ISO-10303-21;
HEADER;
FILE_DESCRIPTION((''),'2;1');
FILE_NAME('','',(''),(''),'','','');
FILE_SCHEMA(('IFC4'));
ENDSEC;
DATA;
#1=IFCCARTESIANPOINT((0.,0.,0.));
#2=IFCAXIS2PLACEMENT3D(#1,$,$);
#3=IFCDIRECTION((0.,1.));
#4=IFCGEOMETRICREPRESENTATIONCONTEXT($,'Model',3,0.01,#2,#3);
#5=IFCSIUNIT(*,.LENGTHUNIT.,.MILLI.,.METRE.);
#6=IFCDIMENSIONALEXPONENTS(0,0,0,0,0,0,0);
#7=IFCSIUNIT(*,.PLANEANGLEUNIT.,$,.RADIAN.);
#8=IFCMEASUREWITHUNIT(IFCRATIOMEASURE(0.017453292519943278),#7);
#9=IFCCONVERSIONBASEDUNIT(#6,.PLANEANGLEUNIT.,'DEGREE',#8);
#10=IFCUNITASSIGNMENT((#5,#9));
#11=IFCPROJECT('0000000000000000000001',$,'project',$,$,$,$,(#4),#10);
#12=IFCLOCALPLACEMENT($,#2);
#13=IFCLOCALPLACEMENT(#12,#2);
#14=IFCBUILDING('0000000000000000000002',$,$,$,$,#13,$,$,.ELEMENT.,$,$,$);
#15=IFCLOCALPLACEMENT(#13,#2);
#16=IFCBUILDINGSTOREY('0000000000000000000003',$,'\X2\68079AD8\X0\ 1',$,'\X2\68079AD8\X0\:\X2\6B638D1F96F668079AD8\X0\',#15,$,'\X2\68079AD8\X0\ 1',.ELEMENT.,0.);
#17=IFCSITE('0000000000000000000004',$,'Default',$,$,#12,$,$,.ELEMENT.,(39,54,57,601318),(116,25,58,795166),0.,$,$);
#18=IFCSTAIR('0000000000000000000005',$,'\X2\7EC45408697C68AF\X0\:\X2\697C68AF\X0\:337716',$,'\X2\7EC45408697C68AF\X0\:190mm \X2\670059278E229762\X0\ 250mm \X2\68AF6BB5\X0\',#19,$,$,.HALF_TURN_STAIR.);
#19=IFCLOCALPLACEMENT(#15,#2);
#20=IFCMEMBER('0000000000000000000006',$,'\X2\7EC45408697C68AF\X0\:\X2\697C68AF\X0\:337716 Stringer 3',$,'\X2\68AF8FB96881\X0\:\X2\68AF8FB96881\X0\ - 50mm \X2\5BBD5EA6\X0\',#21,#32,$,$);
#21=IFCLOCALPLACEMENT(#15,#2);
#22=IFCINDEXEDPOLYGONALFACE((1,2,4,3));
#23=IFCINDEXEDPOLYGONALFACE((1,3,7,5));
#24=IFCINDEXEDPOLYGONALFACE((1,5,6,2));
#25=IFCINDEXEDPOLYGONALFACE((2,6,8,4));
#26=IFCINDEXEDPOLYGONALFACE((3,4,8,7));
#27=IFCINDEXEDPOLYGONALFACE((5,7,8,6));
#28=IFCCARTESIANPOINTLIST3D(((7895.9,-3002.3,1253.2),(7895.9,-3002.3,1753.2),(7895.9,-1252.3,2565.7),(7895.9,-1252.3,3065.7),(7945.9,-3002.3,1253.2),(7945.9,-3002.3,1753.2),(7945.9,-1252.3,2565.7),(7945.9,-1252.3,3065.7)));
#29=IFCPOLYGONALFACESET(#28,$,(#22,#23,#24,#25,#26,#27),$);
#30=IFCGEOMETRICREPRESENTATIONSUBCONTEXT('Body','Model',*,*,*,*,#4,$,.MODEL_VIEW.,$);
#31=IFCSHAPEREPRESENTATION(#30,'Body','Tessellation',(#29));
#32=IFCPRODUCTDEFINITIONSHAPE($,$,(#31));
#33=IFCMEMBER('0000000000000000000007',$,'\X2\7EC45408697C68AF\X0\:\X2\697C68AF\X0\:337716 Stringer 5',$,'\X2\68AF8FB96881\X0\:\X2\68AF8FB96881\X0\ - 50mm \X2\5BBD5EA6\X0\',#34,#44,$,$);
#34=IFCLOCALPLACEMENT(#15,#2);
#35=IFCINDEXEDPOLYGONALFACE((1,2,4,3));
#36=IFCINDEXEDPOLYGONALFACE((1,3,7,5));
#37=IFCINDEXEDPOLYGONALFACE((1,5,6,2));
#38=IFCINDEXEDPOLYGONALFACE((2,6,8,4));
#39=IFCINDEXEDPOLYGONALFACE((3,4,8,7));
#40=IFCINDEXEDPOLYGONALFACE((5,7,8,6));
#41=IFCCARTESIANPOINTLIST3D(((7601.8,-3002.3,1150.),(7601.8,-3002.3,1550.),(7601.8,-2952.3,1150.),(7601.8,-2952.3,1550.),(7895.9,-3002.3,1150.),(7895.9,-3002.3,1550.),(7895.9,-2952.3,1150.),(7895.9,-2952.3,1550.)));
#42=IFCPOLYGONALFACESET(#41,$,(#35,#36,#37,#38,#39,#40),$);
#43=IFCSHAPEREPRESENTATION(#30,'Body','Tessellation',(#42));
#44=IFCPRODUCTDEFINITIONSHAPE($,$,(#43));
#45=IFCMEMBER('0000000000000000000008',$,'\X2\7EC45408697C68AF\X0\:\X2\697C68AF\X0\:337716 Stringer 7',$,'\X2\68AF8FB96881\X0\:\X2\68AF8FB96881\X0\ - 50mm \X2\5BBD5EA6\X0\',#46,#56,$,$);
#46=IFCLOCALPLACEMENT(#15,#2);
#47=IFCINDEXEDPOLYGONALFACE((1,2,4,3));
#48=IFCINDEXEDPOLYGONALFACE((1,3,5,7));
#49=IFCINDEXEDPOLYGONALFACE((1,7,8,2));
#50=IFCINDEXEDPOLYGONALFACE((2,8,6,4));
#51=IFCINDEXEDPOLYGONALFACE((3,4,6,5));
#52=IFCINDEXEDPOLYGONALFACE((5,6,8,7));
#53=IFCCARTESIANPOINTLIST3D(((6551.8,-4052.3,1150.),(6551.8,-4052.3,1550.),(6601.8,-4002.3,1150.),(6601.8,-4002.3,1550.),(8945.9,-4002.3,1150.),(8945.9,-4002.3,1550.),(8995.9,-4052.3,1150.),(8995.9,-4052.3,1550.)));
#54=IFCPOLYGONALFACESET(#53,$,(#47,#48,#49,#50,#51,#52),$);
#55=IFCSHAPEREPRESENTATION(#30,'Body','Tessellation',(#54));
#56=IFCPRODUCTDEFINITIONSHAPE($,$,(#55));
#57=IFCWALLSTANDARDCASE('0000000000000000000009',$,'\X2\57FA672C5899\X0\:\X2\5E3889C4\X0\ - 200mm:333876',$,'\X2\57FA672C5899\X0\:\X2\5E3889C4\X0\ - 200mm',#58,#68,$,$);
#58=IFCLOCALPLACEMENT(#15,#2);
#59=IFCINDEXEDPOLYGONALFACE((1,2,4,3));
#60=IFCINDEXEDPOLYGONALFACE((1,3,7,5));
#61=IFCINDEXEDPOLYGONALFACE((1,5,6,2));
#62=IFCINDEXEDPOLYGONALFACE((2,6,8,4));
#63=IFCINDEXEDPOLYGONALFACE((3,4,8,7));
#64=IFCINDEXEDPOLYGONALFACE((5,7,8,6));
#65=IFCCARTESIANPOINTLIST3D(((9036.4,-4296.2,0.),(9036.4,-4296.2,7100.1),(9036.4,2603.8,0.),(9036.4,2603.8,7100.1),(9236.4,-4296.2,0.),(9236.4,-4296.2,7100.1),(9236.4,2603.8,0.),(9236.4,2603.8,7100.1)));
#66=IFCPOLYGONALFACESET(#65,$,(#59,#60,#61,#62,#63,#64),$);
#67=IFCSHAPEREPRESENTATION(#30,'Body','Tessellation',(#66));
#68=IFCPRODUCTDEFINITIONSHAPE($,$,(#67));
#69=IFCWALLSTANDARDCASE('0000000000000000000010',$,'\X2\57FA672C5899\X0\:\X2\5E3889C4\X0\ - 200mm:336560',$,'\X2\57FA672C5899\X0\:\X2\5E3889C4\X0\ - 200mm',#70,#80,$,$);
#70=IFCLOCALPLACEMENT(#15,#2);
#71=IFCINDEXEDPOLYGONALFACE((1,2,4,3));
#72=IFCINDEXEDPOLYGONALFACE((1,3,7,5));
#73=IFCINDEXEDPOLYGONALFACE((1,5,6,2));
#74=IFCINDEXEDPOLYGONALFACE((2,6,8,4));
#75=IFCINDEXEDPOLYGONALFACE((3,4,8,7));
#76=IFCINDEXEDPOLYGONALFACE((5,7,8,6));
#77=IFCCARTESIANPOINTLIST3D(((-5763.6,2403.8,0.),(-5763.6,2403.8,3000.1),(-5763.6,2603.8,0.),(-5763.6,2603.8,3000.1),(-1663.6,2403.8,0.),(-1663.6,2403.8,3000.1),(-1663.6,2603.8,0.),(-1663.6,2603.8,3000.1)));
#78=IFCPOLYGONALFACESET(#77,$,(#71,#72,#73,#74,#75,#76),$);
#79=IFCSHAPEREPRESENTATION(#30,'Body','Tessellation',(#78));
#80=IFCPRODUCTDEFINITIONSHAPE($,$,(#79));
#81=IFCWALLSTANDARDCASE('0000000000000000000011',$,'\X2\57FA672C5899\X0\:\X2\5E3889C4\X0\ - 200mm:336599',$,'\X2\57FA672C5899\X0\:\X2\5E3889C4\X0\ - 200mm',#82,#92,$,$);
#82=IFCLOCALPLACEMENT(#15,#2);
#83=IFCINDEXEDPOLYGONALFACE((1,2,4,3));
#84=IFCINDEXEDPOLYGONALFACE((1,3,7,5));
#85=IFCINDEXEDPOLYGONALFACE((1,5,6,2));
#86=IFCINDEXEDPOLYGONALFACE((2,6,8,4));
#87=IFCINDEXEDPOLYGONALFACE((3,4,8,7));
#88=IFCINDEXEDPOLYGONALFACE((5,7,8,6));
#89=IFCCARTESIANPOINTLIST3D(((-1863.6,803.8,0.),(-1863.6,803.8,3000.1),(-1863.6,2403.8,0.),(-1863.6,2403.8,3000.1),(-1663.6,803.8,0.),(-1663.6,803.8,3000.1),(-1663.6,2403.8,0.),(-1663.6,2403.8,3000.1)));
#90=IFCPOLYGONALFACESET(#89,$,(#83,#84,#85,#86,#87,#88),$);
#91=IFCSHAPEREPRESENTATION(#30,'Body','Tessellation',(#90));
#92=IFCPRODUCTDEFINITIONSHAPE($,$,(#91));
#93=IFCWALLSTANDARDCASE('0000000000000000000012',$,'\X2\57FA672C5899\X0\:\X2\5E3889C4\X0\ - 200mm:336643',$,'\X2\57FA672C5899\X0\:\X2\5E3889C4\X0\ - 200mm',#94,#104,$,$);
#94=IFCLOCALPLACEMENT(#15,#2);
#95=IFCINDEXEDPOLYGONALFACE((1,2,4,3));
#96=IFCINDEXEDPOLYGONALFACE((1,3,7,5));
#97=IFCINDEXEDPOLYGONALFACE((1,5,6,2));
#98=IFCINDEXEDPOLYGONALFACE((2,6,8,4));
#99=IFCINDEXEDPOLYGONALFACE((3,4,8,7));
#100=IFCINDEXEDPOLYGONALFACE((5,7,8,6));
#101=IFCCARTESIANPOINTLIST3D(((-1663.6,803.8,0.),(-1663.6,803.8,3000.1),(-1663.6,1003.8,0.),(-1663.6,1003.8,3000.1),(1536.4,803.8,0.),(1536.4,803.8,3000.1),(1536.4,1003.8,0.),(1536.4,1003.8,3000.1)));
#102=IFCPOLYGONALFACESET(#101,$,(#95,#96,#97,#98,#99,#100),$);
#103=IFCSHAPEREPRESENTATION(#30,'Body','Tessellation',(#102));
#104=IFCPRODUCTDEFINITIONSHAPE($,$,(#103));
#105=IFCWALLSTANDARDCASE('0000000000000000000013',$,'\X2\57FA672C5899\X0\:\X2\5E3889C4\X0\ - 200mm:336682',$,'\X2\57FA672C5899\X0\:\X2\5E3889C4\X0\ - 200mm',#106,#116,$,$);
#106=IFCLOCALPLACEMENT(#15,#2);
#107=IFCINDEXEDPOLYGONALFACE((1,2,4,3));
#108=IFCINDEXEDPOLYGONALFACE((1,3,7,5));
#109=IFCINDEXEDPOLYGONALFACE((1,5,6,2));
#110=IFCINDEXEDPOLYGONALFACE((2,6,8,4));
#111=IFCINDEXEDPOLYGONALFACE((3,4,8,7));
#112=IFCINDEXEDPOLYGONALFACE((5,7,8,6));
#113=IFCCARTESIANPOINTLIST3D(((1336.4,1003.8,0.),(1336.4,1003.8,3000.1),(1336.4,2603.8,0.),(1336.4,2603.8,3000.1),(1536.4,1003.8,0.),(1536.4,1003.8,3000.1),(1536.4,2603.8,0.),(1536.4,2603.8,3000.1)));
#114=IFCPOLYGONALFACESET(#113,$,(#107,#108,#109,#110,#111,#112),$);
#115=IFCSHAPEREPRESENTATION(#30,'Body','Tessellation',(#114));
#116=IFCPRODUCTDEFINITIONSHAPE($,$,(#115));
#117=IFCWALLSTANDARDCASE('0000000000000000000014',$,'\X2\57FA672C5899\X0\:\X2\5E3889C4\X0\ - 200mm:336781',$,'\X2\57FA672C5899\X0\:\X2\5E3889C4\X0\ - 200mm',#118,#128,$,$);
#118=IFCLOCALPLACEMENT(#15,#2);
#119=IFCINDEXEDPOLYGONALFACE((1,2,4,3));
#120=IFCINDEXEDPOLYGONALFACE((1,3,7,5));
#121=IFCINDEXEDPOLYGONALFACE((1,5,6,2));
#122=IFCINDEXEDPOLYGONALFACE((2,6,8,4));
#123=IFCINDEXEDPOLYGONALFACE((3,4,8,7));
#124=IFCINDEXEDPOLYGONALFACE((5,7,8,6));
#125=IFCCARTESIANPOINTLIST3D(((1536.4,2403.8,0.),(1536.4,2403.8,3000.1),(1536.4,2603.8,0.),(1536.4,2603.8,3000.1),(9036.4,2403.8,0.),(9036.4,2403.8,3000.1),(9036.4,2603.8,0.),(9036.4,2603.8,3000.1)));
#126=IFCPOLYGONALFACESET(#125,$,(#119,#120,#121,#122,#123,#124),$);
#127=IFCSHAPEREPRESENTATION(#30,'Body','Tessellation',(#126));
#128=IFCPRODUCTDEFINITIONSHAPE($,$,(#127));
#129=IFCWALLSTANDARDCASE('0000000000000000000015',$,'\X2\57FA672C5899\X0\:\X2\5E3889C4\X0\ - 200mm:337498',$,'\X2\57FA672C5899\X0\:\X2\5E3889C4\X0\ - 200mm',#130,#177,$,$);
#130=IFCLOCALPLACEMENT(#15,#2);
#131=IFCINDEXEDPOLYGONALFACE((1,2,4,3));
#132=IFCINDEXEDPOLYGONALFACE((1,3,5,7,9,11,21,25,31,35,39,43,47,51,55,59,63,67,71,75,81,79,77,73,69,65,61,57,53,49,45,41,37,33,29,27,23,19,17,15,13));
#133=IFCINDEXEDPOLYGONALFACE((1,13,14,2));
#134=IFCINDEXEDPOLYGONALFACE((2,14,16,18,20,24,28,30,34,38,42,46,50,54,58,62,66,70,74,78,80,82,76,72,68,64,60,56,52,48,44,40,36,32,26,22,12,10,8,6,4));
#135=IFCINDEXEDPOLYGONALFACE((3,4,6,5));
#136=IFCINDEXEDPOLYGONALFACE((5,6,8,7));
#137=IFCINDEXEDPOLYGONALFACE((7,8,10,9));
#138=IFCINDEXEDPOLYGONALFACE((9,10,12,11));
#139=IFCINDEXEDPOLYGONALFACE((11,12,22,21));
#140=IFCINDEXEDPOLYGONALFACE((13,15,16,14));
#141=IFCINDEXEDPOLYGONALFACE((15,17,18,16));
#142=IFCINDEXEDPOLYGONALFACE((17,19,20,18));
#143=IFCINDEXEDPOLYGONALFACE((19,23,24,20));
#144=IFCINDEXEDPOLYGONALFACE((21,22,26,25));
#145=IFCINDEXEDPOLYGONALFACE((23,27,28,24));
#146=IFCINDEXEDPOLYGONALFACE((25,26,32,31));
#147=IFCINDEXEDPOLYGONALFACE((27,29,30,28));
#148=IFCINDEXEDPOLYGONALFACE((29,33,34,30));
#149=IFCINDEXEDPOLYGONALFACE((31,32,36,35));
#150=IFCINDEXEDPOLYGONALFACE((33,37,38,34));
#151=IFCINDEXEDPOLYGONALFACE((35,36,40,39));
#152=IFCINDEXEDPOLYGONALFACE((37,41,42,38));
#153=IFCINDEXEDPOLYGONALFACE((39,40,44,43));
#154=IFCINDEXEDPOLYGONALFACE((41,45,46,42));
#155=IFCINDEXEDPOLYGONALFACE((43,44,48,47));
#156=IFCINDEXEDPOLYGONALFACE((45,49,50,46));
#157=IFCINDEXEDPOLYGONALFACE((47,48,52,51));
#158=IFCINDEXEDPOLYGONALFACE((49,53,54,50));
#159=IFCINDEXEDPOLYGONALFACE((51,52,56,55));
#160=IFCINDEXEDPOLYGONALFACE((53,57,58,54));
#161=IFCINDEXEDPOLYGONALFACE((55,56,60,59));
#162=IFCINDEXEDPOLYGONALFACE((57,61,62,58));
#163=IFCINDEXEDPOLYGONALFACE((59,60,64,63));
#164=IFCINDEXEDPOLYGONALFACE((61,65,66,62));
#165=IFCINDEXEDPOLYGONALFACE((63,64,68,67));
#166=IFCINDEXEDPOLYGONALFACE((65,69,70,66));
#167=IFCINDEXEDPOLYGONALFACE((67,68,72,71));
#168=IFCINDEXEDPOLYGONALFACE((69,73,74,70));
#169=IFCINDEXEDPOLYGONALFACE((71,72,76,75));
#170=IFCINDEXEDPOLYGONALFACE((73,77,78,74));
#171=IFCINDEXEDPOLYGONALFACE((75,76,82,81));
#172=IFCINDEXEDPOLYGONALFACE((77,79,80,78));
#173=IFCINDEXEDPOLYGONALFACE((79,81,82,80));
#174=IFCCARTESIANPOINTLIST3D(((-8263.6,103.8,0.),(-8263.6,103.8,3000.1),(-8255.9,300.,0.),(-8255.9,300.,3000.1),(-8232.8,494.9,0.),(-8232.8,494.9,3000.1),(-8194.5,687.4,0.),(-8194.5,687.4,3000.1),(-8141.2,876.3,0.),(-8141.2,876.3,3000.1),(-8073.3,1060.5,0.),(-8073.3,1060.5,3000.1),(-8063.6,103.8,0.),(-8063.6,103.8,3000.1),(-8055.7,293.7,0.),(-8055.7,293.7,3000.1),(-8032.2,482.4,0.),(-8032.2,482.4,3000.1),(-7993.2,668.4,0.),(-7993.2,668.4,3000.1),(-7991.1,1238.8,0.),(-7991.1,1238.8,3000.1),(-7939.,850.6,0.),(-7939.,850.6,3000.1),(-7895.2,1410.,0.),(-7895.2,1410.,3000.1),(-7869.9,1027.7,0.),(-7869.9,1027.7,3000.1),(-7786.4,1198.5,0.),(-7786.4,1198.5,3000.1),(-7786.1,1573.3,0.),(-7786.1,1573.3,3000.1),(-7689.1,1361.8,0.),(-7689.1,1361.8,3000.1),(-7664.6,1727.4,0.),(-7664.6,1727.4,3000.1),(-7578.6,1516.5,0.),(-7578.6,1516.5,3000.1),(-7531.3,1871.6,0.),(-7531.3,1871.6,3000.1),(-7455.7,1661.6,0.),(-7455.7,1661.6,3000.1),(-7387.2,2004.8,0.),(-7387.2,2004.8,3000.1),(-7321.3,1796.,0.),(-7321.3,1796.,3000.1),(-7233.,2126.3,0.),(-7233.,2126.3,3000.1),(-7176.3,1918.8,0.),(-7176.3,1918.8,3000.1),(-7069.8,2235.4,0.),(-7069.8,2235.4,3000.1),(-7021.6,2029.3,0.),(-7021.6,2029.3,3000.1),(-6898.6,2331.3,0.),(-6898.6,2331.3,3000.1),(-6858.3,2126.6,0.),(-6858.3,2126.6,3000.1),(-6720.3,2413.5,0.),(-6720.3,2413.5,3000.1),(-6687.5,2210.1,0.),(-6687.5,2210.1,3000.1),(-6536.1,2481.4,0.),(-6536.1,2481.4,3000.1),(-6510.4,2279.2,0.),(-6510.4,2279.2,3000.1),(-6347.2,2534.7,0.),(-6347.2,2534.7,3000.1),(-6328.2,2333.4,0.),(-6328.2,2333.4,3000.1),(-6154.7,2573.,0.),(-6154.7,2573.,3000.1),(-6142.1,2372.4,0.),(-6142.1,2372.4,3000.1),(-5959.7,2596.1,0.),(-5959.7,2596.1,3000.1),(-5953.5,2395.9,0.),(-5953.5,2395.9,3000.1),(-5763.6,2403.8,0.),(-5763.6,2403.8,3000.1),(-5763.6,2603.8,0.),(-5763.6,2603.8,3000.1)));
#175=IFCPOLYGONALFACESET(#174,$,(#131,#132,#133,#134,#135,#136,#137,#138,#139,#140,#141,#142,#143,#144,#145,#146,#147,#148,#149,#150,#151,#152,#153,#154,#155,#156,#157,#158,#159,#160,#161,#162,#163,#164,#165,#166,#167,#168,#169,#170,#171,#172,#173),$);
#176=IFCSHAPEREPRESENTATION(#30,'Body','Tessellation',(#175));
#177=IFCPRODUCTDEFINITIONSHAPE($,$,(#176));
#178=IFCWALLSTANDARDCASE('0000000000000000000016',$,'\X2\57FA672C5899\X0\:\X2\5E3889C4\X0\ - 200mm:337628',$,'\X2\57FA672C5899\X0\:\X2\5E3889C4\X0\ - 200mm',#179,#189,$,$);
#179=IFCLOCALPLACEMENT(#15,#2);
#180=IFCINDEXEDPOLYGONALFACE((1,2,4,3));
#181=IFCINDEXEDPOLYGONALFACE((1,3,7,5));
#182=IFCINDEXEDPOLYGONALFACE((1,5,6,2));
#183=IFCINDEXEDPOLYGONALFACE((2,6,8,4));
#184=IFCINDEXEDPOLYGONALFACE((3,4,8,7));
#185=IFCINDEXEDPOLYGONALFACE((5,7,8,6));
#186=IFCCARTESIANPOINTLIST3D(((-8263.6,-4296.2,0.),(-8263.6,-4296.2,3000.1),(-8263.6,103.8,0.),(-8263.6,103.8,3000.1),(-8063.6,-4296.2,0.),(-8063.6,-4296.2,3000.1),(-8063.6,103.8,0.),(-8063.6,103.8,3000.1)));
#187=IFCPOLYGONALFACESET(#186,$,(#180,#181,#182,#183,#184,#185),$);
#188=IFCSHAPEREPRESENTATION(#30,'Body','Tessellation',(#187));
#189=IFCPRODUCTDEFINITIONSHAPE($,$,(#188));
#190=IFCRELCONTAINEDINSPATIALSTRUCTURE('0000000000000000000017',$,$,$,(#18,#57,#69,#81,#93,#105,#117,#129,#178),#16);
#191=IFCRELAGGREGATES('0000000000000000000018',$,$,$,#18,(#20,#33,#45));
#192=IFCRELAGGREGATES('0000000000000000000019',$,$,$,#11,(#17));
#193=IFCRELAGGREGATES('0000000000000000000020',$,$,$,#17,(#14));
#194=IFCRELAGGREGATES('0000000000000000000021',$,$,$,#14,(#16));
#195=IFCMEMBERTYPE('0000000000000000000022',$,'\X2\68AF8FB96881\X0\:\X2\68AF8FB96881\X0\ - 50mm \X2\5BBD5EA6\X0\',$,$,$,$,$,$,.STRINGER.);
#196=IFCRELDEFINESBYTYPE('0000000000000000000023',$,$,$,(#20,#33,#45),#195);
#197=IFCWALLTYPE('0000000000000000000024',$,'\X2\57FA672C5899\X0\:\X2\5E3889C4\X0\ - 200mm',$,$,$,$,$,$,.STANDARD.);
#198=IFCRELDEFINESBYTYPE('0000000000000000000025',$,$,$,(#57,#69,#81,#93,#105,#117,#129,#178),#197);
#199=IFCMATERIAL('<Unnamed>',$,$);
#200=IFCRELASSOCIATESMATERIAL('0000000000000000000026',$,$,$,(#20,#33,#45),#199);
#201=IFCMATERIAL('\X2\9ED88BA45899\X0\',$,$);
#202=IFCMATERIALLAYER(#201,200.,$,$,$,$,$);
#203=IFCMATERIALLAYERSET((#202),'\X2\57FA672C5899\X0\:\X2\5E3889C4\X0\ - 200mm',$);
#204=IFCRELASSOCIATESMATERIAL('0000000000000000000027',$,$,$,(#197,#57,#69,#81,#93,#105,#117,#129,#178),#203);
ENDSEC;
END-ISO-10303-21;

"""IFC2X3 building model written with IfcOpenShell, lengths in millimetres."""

from ifc_helpers import new_model, entity, si_unit, converted_unit, direction, frame, frame_2d, origin, place, context, subcontext, project, spatial, polyline, circle_curve, parameter, trimmed, segment, composite_curve, rectangle, outline, extrude, material, layer, layer_set, layer_usage, type_object, element, aggregate, save


model = new_model("IFC2X3")

# Units and contexts
model_context = context("Model", 3, precision=0.01, world=origin(), true_north=direction((0.0, 1.0)))
body_context = subcontext(model_context, "Body", "Model", "MODEL_VIEW")
ifc_project = project(units=[si_unit("LENGTHUNIT", "METRE", prefix="MILLI"), converted_unit("PLANEANGLEUNIT", "DEGREE", entity("IfcRatioMeasure", 0.017453292519943278), si_unit("PLANEANGLEUNIT", "RADIAN"), dimensions=[0, 0, 0, 0, 0, 0, 0])], contexts=[model_context])

# Site, building, storey
site_placement = place(None, origin())
site = spatial("IfcSite", under=ifc_project, at=site_placement, Name="Default", CompositionType="ELEMENT", RefLatitude=(39, 54, 57, 601318), RefLongitude=(116, 25, 58, 795166), RefElevation=0.0)
building_placement = place(site_placement, origin())
building = spatial("IfcBuilding", under=site, at=building_placement, CompositionType="ELEMENT")
storey_placement = place(building_placement, origin())
storey = spatial("IfcBuildingStorey", under=building, at=storey_placement, Name="标高 1", ObjectType="标高:正负零标高", LongName="标高 1", CompositionType="ELEMENT", Elevation=0.0)

# Stair, members
stair_placement = place(storey_placement, origin())
stair = element("IfcStair", 1, at=stair_placement, inside=storey, Name="组合楼梯:楼梯:337716", ObjectType="组合楼梯:190mm 最大踢面 250mm 梯段", ShapeType="HALF_TURN_STAIR")
ifc_material_1 = material(Name="<Unnamed>")
member_type = type_object("IfcMemberType", Name="梯边梁:梯边梁 - 50mm 宽度", PredefinedType="STRINGER")
member_1_placement = place(stair_placement, origin())
member_1 = element("IfcMember", 2, at=member_1_placement, type_object=member_type, material=ifc_material_1, Name="组合楼梯:楼梯:337716 Stringer 3", ObjectType="梯边梁:梯边梁 - 50mm 宽度", context=body_context, shape_type="SweptSolid", body=[
    extrude(outline(polyline([(-1243.8, -200.0), (943.8, -200.0), (1243.8, 200.0), (-943.8, 200.0), (-1243.8, -200.0)])), frame((7895.9, -2127.3, 2159.4), z_axis=(1.0, 0.0, 0.0), x_axis=(0.0, 0.799993, 0.600009)), (0.0, 0.0, 1.0), 50.0),
])
member_2_placement = place(stair_placement, origin())
member_2 = element("IfcMember", 3, at=member_2_placement, type_object=member_type, material=ifc_material_1, Name="组合楼梯:楼梯:337716 Stringer 5", ObjectType="梯边梁:梯边梁 - 50mm 宽度", context=body_context, shape_type="SweptSolid", body=[
    extrude(rectangle(XDim=294.1, YDim=50.0, at=frame_2d((0.0, 0.0), x_axis=(1.0, 0.0))), frame((7748.9, -2977.3, 1150.0), z_axis=(0.0, 0.0, 1.0), x_axis=(-1.0, 0.0, 0.0)), (0.0, 0.0, 1.0), 400.0),
])
member_3_placement = place(stair_placement, origin())
member_3 = element("IfcMember", 4, at=member_3_placement, type_object=member_type, material=ifc_material_1, Name="组合楼梯:楼梯:337716 Stringer 7", ObjectType="梯边梁:梯边梁 - 50mm 宽度", context=body_context, shape_type="SweptSolid", body=[
    extrude(outline(polyline([(-1222.1, -25.0), (1222.1, -25.0), (1172.1, 25.0), (-1172.1, 25.0), (-1222.1, -25.0)])), frame((7773.9, -4027.3, 1150.0)), (0.0, 0.0, 1.0), 400.0),
])

# Walls
ifc_material_2 = material(Name="默认墙")
ifc_layer_1 = layer(ifc_material_2, 200.0)
ifc_layer_set_1 = layer_set([ifc_layer_1], Name="基本墙:常规 - 200mm")
ifc_layer_usage_1 = layer_usage(ifc_layer_set_1, "AXIS2", "NEGATIVE", 100.0)
wall_type = type_object("IfcWallType", Name="基本墙:常规 - 200mm", PredefinedType="STANDARD", material=ifc_layer_set_1)
wall_1_placement = place(storey_placement, frame((9136.4, 2603.8, 0.0), z_axis=(0.0, 0.0, 1.0), x_axis=(0.0, -1.0, 0.0)))
element("IfcWallStandardCase", 5, at=wall_1_placement, inside=storey, type_object=wall_type, material=ifc_layer_usage_1, Name="基本墙:常规 - 200mm:333876", ObjectType="基本墙:常规 - 200mm", context=body_context, shape_type="SweptSolid", body=[
    extrude(rectangle(XDim=6900.0, YDim=200.0, at=frame_2d((3450.0, 0.0), x_axis=(-1.0, 0.0))), origin(), (0.0, 0.0, 1.0), 7100.1),
])
wall_2_placement = place(storey_placement, frame((-5763.6, 2503.8, 0.0)))
element("IfcWallStandardCase", 6, at=wall_2_placement, inside=storey, type_object=wall_type, material=ifc_layer_usage_1, Name="基本墙:常规 - 200mm:336560", ObjectType="基本墙:常规 - 200mm", context=body_context, shape_type="SweptSolid", body=[
    extrude(rectangle(XDim=4100.0, YDim=200.0, at=frame_2d((2050.0, 0.0), x_axis=(-1.0, 0.0))), origin(), (0.0, 0.0, 1.0), 3000.1),
])
wall_3_placement = place(storey_placement, frame((-1763.6, 2403.8, 0.0), z_axis=(0.0, 0.0, 1.0), x_axis=(0.0, -1.0, 0.0)))
element("IfcWallStandardCase", 7, at=wall_3_placement, inside=storey, type_object=wall_type, material=ifc_layer_usage_1, Name="基本墙:常规 - 200mm:336599", ObjectType="基本墙:常规 - 200mm", context=body_context, shape_type="SweptSolid", body=[
    extrude(rectangle(XDim=1600.0, YDim=200.0, at=frame_2d((800.0, 0.0), x_axis=(-1.0, 0.0))), origin(), (0.0, 0.0, 1.0), 3000.1),
])
wall_4_placement = place(storey_placement, frame((-1663.6, 903.8, 0.0)))
element("IfcWallStandardCase", 8, at=wall_4_placement, inside=storey, type_object=wall_type, material=ifc_layer_usage_1, Name="基本墙:常规 - 200mm:336643", ObjectType="基本墙:常规 - 200mm", context=body_context, shape_type="SweptSolid", body=[
    extrude(rectangle(XDim=3200.0, YDim=200.0, at=frame_2d((1600.0, 0.0), x_axis=(-1.0, 0.0))), origin(), (0.0, 0.0, 1.0), 3000.1),
])
wall_5_placement = place(storey_placement, frame((1436.4, 1003.8, 0.0), z_axis=(0.0, 0.0, 1.0), x_axis=(0.0, 1.0, 0.0)))
element("IfcWallStandardCase", 9, at=wall_5_placement, inside=storey, type_object=wall_type, material=ifc_layer_usage_1, Name="基本墙:常规 - 200mm:336682", ObjectType="基本墙:常规 - 200mm", context=body_context, shape_type="SweptSolid", body=[
    extrude(rectangle(XDim=1600.0, YDim=200.0, at=frame_2d((800.0, 0.0), x_axis=(-1.0, 0.0))), origin(), (0.0, 0.0, 1.0), 3000.1),
])
wall_6_placement = place(storey_placement, frame((1536.4, 2503.8, 0.0)))
element("IfcWallStandardCase", 10, at=wall_6_placement, inside=storey, type_object=wall_type, material=ifc_layer_usage_1, Name="基本墙:常规 - 200mm:336781", ObjectType="基本墙:常规 - 200mm", context=body_context, shape_type="SweptSolid", body=[
    extrude(rectangle(XDim=7500.0, YDim=200.0, at=frame_2d((3750.0, 0.0), x_axis=(-1.0, 0.0))), origin(), (0.0, 0.0, 1.0), 3000.1),
])
wall_7_placement = place(storey_placement, frame((-5763.6, 2503.8, 0.0)))
element("IfcWallStandardCase", 11, at=wall_7_placement, inside=storey, type_object=wall_type, material=ifc_layer_usage_1, Name="基本墙:常规 - 200mm:337498", ObjectType="基本墙:常规 - 200mm", context=body_context, shape_type="SweptSolid", body=[
    extrude(outline(composite_curve([segment(trimmed(circle_curve(frame_2d((0.0, -2400.0), x_axis=(1.0, 0.0)), 2300.0), [parameter(90.0)], [parameter(180.0)], True, "PARAMETER"), False, "CONTINUOUS"), segment(polyline([(0.0, -100.0), (0.0, 100.0)]), True, "CONTINUOUS"), segment(trimmed(circle_curve(frame_2d((0.0, -2400.0), x_axis=(1.0, 0.0)), 2500.0), [parameter(90.0)], [parameter(180.0)], True, "PARAMETER"), True, "CONTINUOUS"), segment(polyline([(-2500.0, -2400.0), (-2300.0, -2400.0)]), True, "CONTINUOUS")], self_intersect=False)), origin(), (0.0, 0.0, 1.0), 3000.1),
])
wall_8_placement = place(storey_placement, frame((-8163.6, 103.8, 0.0), z_axis=(0.0, 0.0, 1.0), x_axis=(0.0, -1.0, 0.0)))
element("IfcWallStandardCase", 12, at=wall_8_placement, inside=storey, type_object=wall_type, material=ifc_layer_usage_1, Name="基本墙:常规 - 200mm:337628", ObjectType="基本墙:常规 - 200mm", context=body_context, shape_type="SweptSolid", body=[
    extrude(rectangle(XDim=4400.0, YDim=200.0, at=frame_2d((2200.0, 0.0), x_axis=(-1.0, 0.0))), origin(), (0.0, 0.0, 1.0), 3000.1),
])

aggregate(stair, [member_1, member_2, member_3])

save(model, "model.ifc")
